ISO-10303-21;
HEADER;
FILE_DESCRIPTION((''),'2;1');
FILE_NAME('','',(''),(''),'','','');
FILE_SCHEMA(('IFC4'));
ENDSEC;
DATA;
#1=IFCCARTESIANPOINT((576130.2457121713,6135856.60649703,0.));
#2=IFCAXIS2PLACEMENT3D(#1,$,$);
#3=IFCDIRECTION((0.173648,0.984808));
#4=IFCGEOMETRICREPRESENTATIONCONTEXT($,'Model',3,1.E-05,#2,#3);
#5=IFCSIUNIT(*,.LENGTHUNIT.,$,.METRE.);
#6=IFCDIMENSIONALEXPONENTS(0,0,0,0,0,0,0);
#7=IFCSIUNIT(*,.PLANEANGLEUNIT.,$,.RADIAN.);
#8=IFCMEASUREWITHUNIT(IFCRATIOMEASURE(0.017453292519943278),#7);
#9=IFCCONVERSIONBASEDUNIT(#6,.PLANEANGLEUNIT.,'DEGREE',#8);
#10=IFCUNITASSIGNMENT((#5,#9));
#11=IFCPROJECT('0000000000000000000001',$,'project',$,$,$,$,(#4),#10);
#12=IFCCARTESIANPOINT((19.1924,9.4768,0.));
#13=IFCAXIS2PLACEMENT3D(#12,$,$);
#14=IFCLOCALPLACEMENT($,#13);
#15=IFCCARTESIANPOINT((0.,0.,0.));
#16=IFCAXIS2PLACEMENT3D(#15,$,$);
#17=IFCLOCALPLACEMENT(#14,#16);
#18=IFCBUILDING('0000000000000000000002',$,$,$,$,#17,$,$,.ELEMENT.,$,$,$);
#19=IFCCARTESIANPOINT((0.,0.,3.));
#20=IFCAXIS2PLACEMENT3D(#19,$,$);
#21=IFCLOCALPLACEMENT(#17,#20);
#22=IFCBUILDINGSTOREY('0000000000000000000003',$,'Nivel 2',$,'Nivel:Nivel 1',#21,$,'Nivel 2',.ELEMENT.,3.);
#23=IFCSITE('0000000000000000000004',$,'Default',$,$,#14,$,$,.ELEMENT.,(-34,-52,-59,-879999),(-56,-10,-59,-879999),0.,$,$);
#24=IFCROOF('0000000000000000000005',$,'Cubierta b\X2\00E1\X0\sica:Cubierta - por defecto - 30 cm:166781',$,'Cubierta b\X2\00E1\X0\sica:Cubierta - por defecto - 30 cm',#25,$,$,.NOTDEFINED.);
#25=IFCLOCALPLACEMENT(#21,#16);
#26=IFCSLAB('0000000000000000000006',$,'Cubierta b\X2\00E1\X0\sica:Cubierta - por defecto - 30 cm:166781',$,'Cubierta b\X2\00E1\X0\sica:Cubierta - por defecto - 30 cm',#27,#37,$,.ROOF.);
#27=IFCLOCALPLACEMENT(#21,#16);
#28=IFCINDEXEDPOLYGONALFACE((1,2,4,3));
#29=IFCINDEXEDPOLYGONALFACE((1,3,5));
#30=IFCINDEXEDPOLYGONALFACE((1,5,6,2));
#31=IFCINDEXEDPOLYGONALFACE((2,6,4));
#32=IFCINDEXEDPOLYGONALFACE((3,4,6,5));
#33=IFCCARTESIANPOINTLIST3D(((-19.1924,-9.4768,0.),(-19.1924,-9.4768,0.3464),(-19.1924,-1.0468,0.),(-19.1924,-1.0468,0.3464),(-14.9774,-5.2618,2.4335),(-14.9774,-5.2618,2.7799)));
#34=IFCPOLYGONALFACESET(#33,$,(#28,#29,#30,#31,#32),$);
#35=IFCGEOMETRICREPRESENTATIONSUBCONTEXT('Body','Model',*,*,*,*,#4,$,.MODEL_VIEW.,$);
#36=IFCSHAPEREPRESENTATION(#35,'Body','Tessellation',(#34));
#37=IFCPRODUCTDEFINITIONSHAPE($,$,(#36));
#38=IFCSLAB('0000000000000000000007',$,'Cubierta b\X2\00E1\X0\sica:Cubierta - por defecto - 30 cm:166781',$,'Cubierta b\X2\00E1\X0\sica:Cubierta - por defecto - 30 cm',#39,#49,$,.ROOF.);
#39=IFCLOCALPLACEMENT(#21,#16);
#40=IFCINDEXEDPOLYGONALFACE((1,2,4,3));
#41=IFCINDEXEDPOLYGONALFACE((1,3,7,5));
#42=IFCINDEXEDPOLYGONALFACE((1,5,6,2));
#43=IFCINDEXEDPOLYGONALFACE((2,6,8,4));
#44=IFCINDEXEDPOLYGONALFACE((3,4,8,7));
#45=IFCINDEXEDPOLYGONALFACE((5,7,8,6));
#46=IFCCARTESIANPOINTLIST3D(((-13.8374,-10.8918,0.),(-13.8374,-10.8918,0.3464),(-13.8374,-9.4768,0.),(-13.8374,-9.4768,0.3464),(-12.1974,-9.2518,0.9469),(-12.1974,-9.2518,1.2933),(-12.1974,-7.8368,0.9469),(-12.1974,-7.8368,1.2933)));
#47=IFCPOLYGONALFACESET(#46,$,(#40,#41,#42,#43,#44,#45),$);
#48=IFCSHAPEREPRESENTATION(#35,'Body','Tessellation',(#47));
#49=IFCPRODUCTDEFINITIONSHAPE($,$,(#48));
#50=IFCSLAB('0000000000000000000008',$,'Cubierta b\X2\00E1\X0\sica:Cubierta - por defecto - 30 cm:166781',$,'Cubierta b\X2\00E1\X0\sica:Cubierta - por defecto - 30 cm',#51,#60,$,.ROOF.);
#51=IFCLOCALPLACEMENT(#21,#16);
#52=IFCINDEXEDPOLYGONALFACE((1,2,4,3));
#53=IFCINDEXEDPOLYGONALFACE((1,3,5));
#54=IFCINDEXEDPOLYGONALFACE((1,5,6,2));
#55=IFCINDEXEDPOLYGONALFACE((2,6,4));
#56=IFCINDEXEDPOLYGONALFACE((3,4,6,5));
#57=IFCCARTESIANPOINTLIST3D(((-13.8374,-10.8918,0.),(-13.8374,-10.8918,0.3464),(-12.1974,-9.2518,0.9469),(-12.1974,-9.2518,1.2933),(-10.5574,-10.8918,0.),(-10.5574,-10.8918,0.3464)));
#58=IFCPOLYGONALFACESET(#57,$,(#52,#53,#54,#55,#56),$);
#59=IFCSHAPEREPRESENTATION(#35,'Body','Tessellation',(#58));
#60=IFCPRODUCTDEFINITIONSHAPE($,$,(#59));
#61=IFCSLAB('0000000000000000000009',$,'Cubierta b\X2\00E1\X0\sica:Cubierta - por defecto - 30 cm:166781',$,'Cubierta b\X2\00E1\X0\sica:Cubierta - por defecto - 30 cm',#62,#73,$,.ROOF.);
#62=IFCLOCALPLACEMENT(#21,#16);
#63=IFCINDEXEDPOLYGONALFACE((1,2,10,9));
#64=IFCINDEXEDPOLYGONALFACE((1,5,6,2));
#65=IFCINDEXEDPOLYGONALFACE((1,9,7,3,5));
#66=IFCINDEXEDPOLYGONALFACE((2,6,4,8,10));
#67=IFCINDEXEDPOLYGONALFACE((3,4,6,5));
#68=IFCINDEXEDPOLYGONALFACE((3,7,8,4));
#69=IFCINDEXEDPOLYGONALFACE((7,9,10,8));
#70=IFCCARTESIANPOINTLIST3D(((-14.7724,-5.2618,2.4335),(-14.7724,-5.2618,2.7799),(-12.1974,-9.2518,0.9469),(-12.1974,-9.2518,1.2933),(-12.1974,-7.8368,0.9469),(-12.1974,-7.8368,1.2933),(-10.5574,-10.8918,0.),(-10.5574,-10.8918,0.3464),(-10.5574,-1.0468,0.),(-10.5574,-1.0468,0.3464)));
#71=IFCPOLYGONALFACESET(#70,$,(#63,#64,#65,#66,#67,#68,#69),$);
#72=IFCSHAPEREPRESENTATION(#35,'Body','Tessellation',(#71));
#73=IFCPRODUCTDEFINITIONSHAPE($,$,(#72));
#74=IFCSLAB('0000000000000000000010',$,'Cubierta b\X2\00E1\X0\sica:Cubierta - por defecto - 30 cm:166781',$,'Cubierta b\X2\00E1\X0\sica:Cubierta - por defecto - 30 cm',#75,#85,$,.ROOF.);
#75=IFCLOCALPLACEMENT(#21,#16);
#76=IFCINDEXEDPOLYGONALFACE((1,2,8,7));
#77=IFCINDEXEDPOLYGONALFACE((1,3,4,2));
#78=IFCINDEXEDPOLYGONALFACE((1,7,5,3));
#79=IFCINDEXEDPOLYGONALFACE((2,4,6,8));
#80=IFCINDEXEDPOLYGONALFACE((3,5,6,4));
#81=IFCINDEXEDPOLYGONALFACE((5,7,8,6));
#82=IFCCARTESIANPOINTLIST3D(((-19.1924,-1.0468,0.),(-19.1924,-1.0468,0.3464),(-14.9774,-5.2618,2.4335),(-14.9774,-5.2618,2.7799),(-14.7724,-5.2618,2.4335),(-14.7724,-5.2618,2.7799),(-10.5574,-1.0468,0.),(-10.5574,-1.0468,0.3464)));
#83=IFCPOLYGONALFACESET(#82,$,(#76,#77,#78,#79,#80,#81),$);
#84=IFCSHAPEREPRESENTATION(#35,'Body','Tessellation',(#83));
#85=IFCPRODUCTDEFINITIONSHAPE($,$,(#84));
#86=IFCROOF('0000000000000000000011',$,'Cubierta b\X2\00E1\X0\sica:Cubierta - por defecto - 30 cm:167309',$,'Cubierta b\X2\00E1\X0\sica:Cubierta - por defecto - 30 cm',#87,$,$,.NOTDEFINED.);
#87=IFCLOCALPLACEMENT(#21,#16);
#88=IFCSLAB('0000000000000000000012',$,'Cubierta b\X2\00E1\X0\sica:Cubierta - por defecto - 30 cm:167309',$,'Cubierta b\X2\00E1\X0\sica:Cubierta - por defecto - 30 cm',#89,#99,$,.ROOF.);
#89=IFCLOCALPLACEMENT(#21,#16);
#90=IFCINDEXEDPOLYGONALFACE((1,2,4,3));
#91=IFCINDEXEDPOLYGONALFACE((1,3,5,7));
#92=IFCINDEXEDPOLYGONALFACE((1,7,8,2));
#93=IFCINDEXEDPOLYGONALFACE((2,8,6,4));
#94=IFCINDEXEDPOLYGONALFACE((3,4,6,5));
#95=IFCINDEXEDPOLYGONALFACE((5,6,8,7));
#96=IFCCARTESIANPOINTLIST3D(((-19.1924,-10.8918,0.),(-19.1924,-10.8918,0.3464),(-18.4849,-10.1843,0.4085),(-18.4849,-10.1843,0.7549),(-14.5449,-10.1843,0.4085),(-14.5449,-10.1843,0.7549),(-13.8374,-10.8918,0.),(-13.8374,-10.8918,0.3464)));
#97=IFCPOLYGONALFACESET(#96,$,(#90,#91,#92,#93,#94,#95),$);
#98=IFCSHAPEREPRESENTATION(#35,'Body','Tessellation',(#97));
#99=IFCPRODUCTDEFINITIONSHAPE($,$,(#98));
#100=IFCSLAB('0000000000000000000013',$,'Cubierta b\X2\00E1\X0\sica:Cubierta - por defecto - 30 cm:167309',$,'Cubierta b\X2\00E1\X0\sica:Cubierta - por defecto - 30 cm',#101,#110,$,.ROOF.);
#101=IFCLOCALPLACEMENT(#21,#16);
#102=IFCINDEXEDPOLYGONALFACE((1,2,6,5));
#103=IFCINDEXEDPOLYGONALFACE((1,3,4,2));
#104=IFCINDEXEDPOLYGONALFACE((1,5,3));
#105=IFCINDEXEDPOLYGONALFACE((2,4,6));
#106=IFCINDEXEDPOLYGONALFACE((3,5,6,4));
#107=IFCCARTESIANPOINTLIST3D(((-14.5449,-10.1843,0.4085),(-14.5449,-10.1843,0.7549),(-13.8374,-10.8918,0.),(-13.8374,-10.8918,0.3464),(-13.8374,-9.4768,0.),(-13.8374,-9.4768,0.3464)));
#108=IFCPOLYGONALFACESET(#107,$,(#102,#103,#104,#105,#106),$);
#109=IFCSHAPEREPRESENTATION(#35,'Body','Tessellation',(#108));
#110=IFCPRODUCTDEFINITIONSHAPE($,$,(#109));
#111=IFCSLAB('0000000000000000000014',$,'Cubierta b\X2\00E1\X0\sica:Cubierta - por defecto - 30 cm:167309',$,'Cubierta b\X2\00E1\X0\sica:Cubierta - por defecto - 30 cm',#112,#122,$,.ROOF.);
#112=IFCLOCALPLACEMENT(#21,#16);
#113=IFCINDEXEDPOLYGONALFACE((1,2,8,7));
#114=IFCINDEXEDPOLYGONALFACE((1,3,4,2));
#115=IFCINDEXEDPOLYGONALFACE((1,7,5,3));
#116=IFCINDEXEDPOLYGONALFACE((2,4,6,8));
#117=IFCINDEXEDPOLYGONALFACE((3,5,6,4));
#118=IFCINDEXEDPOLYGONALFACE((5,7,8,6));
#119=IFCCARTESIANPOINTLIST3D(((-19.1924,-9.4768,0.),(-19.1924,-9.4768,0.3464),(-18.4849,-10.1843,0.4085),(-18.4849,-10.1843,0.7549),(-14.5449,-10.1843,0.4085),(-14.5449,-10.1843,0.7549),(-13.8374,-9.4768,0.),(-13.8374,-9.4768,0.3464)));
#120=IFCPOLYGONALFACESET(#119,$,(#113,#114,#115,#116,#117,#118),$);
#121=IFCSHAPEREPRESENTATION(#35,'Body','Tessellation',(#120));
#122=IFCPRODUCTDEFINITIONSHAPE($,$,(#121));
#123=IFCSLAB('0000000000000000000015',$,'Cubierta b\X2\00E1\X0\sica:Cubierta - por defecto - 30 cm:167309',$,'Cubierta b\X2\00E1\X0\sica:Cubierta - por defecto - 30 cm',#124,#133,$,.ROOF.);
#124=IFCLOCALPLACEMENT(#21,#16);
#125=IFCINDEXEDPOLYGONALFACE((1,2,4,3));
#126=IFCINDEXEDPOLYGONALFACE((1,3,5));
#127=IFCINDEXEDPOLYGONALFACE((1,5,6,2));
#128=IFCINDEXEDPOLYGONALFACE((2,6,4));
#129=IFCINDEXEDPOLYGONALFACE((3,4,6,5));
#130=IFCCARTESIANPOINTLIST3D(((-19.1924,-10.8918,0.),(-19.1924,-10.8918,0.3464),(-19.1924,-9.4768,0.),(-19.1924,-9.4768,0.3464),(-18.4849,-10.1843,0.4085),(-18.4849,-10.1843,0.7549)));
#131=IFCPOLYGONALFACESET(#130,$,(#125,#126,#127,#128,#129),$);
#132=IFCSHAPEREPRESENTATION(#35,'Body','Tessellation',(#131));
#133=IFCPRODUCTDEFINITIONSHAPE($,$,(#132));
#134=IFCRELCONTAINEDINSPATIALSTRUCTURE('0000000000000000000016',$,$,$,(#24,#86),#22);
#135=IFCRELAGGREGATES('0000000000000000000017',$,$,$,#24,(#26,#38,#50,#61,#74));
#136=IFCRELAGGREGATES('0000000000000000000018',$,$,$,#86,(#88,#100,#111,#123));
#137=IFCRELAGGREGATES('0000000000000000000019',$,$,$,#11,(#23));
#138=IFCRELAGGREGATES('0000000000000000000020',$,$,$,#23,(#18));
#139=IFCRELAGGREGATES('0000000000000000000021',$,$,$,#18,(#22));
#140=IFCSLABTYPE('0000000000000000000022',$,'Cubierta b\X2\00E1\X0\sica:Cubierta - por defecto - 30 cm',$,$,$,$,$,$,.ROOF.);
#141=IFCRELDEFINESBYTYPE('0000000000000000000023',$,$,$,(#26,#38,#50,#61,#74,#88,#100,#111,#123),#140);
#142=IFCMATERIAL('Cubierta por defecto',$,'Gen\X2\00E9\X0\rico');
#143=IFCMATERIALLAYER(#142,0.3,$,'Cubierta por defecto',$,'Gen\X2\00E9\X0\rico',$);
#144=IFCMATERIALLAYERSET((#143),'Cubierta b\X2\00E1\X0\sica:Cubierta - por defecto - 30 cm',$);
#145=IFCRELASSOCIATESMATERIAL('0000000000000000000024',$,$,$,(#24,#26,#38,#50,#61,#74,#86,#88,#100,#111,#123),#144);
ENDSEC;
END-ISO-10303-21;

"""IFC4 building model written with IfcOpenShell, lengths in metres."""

from ifc_helpers import new_model, entity, si_unit, converted_unit, direction, frame, origin, place, context, subcontext, project, spatial, polyline, outline, extrude, material, layer, layer_set, type_object, element, aggregate, save


model = new_model("IFC4")

# Units and contexts
model_context = context("Model", 3, precision=1e-05, world=frame((576130.2457121713, 6135856.60649703, 0.0)), true_north=direction((0.173648, 0.984808)))
body_context = subcontext(model_context, "Body", "Model", "MODEL_VIEW")
ifc_project = project(units=[si_unit("LENGTHUNIT", "METRE"), converted_unit("PLANEANGLEUNIT", "DEGREE", entity("IfcRatioMeasure", 0.017453292519943278), si_unit("PLANEANGLEUNIT", "RADIAN"), dimensions=[0, 0, 0, 0, 0, 0, 0])], contexts=[model_context])

# Site, building, storey
site_placement = place(None, frame((19.1924, 9.4768, 0.0)))
site = spatial("IfcSite", under=ifc_project, at=site_placement, Name="Default", CompositionType="ELEMENT", RefLatitude=(-34, -52, -59, -879999), RefLongitude=(-56, -10, -59, -879999), RefElevation=0.0)
building_placement = place(site_placement, origin())
building = spatial("IfcBuilding", under=site, at=building_placement, CompositionType="ELEMENT")
storey_placement = place(building_placement, frame((0.0, 0.0, 3.0)))
storey = spatial("IfcBuildingStorey", under=building, at=storey_placement, Name="Nivel 2", ObjectType="Nivel:Nivel 1", LongName="Nivel 2", CompositionType="ELEMENT", Elevation=3.0)

# Roofs, slabs
ifc_material = material(Name="Cubierta por defecto", Category="Genérico")
ifc_layer = layer(ifc_material, 0.3, Name="Cubierta por defecto", Category="Genérico")
ifc_layer_set = layer_set([ifc_layer], Name="Cubierta básica:Cubierta - por defecto - 30 cm")
roof_1_placement = place(storey_placement, frame((-19.1924, -10.8918, 0.0)))
roof_1 = element("IfcRoof", 1, at=roof_1_placement, inside=storey, material=ifc_layer_set, Name="Cubierta básica:Cubierta - por defecto - 30 cm:166781", ObjectType="Cubierta básica:Cubierta - por defecto - 30 cm", PredefinedType="NOTDEFINED")
slab_type = type_object("IfcSlabType", Name="Cubierta básica:Cubierta - por defecto - 30 cm", PredefinedType="ROOF")
slab_1_placement = place(roof_1_placement, origin())
slab_1 = element("IfcSlab", 2, at=slab_1_placement, type_object=slab_type, material=ifc_layer_set, Name="Cubierta básica:Cubierta - por defecto - 30 cm:166781", ObjectType="Cubierta básica:Cubierta - por defecto - 30 cm", PredefinedType="ROOF", context=body_context, shape_type="SweptSolid", body=[
    extrude(outline(polyline([(-2.4335, -4.215), (2.4335, 0.0), (-2.4335, 4.215), (-2.4335, -4.215)])), frame((2.1075, 5.63, 1.2168), z_axis=(-0.5, 0.0, 0.866025), x_axis=(0.866025, 0.0, 0.5)), (0.5, 0.0, 0.866025), 0.3464),
])
slab_2_placement = place(roof_1_placement, origin())
slab_2 = element("IfcSlab", 3, at=slab_2_placement, type_object=slab_type, material=ifc_layer_set, Name="Cubierta básica:Cubierta - por defecto - 30 cm:166781", ObjectType="Cubierta básica:Cubierta - por defecto - 30 cm", PredefinedType="ROOF", context=body_context, shape_type="SweptSolid", body=[
    extrude(outline(polyline([(-0.9469, -1.5275), (0.9469, 0.1125), (0.9469, 1.5275), (-0.9469, -0.1125), (-0.9469, -1.5275)])), frame((6.175, 1.5275, 0.4734), z_axis=(-0.5, 0.0, 0.866025), x_axis=(0.866025, 0.0, 0.5)), (0.5, 0.0, 0.866025), 0.3464),
])
slab_3_placement = place(roof_1_placement, origin())
slab_3 = element("IfcSlab", 4, at=slab_3_placement, type_object=slab_type, material=ifc_layer_set, Name="Cubierta básica:Cubierta - por defecto - 30 cm:166781", ObjectType="Cubierta básica:Cubierta - por defecto - 30 cm", PredefinedType="ROOF", context=body_context, shape_type="SweptSolid", body=[
    extrude(outline(polyline([(-1.64, -0.9469), (1.64, -0.9469), (0.0, 0.9469), (-1.64, -0.9469)])), frame((6.995, 0.82, 0.4734), z_axis=(0.0, -0.5, 0.866025), x_axis=(1.0, 0.0, 0.0)), (0.0, 0.5, 0.866025), 0.3464),
])
slab_4_placement = place(roof_1_placement, origin())
slab_4 = element("IfcSlab", 5, at=slab_4_placement, type_object=slab_type, material=ifc_layer_set, Name="Cubierta básica:Cubierta - por defecto - 30 cm:166781", ObjectType="Cubierta básica:Cubierta - por defecto - 30 cm", PredefinedType="ROOF", context=body_context, shape_type="SweptSolid", body=[
    extrude(outline(polyline([(2.4335, -4.9225), (2.4335, 4.9225), (-2.4335, 0.7075), (0.5398, -1.8675), (0.5398, -3.2825), (2.4335, -4.9225)])), frame((6.5275, 4.9225, 1.2168), z_axis=(0.5, 0.0, 0.866025), x_axis=(0.866025, 0.0, -0.5)), (-0.5, 0.0, 0.866025), 0.3464),
])
slab_5_placement = place(roof_1_placement, origin())
slab_5 = element("IfcSlab", 6, at=slab_5_placement, type_object=slab_type, material=ifc_layer_set, Name="Cubierta básica:Cubierta - por defecto - 30 cm:166781", ObjectType="Cubierta básica:Cubierta - por defecto - 30 cm", PredefinedType="ROOF", context=body_context, shape_type="SweptSolid", body=[
    extrude(outline(polyline([(4.3175, 2.4335), (-4.3175, 2.4335), (-0.1025, -2.4335), (0.1025, -2.4335), (4.3175, 2.4335)])), frame((4.3175, 7.7375, 1.2168), z_axis=(0.0, 0.5, 0.866025), x_axis=(1.0, 0.0, 0.0)), (0.0, -0.5, 0.866025), 0.3464),
])
aggregate(roof_1, [slab_1, slab_2, slab_3, slab_4, slab_5])
roof_2_placement = place(storey_placement, frame((-19.1924, -10.8918, 0.0)))
roof_2 = element("IfcRoof", 7, at=roof_2_placement, inside=storey, material=ifc_layer_set, Name="Cubierta básica:Cubierta - por defecto - 30 cm:167309", ObjectType="Cubierta básica:Cubierta - por defecto - 30 cm", PredefinedType="NOTDEFINED")
slab_6_placement = place(roof_2_placement, origin())
slab_6 = element("IfcSlab", 8, at=slab_6_placement, type_object=slab_type, material=ifc_layer_set, Name="Cubierta básica:Cubierta - por defecto - 30 cm:167309", ObjectType="Cubierta básica:Cubierta - por defecto - 30 cm", PredefinedType="ROOF", context=body_context, shape_type="SweptSolid", body=[
    extrude(outline(polyline([(-2.6775, -0.4085), (2.6775, -0.4085), (1.97, 0.4085), (-1.97, 0.4085), (-2.6775, -0.4085)])), frame((2.6775, 0.3538, 0.2042), z_axis=(0.0, -0.5, 0.866025), x_axis=(1.0, 0.0, 0.0)), (0.0, 0.5, 0.866025), 0.3464),
])
slab_7_placement = place(roof_2_placement, origin())
slab_7 = element("IfcSlab", 9, at=slab_7_placement, type_object=slab_type, material=ifc_layer_set, Name="Cubierta básica:Cubierta - por defecto - 30 cm:167309", ObjectType="Cubierta básica:Cubierta - por defecto - 30 cm", PredefinedType="ROOF", context=body_context, shape_type="SweptSolid", body=[
    extrude(outline(polyline([(0.4085, -0.7075), (0.4085, 0.7075), (-0.4085, 0.0), (0.4085, -0.7075)])), frame((5.0012, 0.7075, 0.2042), z_axis=(0.5, 0.0, 0.866025), x_axis=(0.866025, 0.0, -0.5)), (-0.5, 0.0, 0.866025), 0.3464),
])
slab_8_placement = place(roof_2_placement, origin())
slab_8 = element("IfcSlab", 10, at=slab_8_placement, type_object=slab_type, material=ifc_layer_set, Name="Cubierta básica:Cubierta - por defecto - 30 cm:167309", ObjectType="Cubierta básica:Cubierta - por defecto - 30 cm", PredefinedType="ROOF", context=body_context, shape_type="SweptSolid", body=[
    extrude(outline(polyline([(2.6775, 0.4085), (-2.6775, 0.4085), (-1.97, -0.4085), (1.97, -0.4085), (2.6775, 0.4085)])), frame((2.6775, 1.0613, 0.2042), z_axis=(0.0, 0.5, 0.866025), x_axis=(1.0, 0.0, 0.0)), (0.0, -0.5, 0.866025), 0.3464),
])
slab_9_placement = place(roof_2_placement, origin())
slab_9 = element("IfcSlab", 11, at=slab_9_placement, type_object=slab_type, material=ifc_layer_set, Name="Cubierta básica:Cubierta - por defecto - 30 cm:167309", ObjectType="Cubierta básica:Cubierta - por defecto - 30 cm", PredefinedType="ROOF", context=body_context, shape_type="SweptSolid", body=[
    extrude(outline(polyline([(0.4085, 0.0), (-0.4085, 0.7075), (-0.4085, -0.7075), (0.4085, 0.0)])), frame((0.3538, 0.7075, 0.2042), z_axis=(-0.5, 0.0, 0.866025), x_axis=(0.866025, 0.0, 0.5)), (0.5, 0.0, 0.866025), 0.3464),
])
aggregate(roof_2, [slab_6, slab_7, slab_8, slab_9])

save(model, "model.ifc")
